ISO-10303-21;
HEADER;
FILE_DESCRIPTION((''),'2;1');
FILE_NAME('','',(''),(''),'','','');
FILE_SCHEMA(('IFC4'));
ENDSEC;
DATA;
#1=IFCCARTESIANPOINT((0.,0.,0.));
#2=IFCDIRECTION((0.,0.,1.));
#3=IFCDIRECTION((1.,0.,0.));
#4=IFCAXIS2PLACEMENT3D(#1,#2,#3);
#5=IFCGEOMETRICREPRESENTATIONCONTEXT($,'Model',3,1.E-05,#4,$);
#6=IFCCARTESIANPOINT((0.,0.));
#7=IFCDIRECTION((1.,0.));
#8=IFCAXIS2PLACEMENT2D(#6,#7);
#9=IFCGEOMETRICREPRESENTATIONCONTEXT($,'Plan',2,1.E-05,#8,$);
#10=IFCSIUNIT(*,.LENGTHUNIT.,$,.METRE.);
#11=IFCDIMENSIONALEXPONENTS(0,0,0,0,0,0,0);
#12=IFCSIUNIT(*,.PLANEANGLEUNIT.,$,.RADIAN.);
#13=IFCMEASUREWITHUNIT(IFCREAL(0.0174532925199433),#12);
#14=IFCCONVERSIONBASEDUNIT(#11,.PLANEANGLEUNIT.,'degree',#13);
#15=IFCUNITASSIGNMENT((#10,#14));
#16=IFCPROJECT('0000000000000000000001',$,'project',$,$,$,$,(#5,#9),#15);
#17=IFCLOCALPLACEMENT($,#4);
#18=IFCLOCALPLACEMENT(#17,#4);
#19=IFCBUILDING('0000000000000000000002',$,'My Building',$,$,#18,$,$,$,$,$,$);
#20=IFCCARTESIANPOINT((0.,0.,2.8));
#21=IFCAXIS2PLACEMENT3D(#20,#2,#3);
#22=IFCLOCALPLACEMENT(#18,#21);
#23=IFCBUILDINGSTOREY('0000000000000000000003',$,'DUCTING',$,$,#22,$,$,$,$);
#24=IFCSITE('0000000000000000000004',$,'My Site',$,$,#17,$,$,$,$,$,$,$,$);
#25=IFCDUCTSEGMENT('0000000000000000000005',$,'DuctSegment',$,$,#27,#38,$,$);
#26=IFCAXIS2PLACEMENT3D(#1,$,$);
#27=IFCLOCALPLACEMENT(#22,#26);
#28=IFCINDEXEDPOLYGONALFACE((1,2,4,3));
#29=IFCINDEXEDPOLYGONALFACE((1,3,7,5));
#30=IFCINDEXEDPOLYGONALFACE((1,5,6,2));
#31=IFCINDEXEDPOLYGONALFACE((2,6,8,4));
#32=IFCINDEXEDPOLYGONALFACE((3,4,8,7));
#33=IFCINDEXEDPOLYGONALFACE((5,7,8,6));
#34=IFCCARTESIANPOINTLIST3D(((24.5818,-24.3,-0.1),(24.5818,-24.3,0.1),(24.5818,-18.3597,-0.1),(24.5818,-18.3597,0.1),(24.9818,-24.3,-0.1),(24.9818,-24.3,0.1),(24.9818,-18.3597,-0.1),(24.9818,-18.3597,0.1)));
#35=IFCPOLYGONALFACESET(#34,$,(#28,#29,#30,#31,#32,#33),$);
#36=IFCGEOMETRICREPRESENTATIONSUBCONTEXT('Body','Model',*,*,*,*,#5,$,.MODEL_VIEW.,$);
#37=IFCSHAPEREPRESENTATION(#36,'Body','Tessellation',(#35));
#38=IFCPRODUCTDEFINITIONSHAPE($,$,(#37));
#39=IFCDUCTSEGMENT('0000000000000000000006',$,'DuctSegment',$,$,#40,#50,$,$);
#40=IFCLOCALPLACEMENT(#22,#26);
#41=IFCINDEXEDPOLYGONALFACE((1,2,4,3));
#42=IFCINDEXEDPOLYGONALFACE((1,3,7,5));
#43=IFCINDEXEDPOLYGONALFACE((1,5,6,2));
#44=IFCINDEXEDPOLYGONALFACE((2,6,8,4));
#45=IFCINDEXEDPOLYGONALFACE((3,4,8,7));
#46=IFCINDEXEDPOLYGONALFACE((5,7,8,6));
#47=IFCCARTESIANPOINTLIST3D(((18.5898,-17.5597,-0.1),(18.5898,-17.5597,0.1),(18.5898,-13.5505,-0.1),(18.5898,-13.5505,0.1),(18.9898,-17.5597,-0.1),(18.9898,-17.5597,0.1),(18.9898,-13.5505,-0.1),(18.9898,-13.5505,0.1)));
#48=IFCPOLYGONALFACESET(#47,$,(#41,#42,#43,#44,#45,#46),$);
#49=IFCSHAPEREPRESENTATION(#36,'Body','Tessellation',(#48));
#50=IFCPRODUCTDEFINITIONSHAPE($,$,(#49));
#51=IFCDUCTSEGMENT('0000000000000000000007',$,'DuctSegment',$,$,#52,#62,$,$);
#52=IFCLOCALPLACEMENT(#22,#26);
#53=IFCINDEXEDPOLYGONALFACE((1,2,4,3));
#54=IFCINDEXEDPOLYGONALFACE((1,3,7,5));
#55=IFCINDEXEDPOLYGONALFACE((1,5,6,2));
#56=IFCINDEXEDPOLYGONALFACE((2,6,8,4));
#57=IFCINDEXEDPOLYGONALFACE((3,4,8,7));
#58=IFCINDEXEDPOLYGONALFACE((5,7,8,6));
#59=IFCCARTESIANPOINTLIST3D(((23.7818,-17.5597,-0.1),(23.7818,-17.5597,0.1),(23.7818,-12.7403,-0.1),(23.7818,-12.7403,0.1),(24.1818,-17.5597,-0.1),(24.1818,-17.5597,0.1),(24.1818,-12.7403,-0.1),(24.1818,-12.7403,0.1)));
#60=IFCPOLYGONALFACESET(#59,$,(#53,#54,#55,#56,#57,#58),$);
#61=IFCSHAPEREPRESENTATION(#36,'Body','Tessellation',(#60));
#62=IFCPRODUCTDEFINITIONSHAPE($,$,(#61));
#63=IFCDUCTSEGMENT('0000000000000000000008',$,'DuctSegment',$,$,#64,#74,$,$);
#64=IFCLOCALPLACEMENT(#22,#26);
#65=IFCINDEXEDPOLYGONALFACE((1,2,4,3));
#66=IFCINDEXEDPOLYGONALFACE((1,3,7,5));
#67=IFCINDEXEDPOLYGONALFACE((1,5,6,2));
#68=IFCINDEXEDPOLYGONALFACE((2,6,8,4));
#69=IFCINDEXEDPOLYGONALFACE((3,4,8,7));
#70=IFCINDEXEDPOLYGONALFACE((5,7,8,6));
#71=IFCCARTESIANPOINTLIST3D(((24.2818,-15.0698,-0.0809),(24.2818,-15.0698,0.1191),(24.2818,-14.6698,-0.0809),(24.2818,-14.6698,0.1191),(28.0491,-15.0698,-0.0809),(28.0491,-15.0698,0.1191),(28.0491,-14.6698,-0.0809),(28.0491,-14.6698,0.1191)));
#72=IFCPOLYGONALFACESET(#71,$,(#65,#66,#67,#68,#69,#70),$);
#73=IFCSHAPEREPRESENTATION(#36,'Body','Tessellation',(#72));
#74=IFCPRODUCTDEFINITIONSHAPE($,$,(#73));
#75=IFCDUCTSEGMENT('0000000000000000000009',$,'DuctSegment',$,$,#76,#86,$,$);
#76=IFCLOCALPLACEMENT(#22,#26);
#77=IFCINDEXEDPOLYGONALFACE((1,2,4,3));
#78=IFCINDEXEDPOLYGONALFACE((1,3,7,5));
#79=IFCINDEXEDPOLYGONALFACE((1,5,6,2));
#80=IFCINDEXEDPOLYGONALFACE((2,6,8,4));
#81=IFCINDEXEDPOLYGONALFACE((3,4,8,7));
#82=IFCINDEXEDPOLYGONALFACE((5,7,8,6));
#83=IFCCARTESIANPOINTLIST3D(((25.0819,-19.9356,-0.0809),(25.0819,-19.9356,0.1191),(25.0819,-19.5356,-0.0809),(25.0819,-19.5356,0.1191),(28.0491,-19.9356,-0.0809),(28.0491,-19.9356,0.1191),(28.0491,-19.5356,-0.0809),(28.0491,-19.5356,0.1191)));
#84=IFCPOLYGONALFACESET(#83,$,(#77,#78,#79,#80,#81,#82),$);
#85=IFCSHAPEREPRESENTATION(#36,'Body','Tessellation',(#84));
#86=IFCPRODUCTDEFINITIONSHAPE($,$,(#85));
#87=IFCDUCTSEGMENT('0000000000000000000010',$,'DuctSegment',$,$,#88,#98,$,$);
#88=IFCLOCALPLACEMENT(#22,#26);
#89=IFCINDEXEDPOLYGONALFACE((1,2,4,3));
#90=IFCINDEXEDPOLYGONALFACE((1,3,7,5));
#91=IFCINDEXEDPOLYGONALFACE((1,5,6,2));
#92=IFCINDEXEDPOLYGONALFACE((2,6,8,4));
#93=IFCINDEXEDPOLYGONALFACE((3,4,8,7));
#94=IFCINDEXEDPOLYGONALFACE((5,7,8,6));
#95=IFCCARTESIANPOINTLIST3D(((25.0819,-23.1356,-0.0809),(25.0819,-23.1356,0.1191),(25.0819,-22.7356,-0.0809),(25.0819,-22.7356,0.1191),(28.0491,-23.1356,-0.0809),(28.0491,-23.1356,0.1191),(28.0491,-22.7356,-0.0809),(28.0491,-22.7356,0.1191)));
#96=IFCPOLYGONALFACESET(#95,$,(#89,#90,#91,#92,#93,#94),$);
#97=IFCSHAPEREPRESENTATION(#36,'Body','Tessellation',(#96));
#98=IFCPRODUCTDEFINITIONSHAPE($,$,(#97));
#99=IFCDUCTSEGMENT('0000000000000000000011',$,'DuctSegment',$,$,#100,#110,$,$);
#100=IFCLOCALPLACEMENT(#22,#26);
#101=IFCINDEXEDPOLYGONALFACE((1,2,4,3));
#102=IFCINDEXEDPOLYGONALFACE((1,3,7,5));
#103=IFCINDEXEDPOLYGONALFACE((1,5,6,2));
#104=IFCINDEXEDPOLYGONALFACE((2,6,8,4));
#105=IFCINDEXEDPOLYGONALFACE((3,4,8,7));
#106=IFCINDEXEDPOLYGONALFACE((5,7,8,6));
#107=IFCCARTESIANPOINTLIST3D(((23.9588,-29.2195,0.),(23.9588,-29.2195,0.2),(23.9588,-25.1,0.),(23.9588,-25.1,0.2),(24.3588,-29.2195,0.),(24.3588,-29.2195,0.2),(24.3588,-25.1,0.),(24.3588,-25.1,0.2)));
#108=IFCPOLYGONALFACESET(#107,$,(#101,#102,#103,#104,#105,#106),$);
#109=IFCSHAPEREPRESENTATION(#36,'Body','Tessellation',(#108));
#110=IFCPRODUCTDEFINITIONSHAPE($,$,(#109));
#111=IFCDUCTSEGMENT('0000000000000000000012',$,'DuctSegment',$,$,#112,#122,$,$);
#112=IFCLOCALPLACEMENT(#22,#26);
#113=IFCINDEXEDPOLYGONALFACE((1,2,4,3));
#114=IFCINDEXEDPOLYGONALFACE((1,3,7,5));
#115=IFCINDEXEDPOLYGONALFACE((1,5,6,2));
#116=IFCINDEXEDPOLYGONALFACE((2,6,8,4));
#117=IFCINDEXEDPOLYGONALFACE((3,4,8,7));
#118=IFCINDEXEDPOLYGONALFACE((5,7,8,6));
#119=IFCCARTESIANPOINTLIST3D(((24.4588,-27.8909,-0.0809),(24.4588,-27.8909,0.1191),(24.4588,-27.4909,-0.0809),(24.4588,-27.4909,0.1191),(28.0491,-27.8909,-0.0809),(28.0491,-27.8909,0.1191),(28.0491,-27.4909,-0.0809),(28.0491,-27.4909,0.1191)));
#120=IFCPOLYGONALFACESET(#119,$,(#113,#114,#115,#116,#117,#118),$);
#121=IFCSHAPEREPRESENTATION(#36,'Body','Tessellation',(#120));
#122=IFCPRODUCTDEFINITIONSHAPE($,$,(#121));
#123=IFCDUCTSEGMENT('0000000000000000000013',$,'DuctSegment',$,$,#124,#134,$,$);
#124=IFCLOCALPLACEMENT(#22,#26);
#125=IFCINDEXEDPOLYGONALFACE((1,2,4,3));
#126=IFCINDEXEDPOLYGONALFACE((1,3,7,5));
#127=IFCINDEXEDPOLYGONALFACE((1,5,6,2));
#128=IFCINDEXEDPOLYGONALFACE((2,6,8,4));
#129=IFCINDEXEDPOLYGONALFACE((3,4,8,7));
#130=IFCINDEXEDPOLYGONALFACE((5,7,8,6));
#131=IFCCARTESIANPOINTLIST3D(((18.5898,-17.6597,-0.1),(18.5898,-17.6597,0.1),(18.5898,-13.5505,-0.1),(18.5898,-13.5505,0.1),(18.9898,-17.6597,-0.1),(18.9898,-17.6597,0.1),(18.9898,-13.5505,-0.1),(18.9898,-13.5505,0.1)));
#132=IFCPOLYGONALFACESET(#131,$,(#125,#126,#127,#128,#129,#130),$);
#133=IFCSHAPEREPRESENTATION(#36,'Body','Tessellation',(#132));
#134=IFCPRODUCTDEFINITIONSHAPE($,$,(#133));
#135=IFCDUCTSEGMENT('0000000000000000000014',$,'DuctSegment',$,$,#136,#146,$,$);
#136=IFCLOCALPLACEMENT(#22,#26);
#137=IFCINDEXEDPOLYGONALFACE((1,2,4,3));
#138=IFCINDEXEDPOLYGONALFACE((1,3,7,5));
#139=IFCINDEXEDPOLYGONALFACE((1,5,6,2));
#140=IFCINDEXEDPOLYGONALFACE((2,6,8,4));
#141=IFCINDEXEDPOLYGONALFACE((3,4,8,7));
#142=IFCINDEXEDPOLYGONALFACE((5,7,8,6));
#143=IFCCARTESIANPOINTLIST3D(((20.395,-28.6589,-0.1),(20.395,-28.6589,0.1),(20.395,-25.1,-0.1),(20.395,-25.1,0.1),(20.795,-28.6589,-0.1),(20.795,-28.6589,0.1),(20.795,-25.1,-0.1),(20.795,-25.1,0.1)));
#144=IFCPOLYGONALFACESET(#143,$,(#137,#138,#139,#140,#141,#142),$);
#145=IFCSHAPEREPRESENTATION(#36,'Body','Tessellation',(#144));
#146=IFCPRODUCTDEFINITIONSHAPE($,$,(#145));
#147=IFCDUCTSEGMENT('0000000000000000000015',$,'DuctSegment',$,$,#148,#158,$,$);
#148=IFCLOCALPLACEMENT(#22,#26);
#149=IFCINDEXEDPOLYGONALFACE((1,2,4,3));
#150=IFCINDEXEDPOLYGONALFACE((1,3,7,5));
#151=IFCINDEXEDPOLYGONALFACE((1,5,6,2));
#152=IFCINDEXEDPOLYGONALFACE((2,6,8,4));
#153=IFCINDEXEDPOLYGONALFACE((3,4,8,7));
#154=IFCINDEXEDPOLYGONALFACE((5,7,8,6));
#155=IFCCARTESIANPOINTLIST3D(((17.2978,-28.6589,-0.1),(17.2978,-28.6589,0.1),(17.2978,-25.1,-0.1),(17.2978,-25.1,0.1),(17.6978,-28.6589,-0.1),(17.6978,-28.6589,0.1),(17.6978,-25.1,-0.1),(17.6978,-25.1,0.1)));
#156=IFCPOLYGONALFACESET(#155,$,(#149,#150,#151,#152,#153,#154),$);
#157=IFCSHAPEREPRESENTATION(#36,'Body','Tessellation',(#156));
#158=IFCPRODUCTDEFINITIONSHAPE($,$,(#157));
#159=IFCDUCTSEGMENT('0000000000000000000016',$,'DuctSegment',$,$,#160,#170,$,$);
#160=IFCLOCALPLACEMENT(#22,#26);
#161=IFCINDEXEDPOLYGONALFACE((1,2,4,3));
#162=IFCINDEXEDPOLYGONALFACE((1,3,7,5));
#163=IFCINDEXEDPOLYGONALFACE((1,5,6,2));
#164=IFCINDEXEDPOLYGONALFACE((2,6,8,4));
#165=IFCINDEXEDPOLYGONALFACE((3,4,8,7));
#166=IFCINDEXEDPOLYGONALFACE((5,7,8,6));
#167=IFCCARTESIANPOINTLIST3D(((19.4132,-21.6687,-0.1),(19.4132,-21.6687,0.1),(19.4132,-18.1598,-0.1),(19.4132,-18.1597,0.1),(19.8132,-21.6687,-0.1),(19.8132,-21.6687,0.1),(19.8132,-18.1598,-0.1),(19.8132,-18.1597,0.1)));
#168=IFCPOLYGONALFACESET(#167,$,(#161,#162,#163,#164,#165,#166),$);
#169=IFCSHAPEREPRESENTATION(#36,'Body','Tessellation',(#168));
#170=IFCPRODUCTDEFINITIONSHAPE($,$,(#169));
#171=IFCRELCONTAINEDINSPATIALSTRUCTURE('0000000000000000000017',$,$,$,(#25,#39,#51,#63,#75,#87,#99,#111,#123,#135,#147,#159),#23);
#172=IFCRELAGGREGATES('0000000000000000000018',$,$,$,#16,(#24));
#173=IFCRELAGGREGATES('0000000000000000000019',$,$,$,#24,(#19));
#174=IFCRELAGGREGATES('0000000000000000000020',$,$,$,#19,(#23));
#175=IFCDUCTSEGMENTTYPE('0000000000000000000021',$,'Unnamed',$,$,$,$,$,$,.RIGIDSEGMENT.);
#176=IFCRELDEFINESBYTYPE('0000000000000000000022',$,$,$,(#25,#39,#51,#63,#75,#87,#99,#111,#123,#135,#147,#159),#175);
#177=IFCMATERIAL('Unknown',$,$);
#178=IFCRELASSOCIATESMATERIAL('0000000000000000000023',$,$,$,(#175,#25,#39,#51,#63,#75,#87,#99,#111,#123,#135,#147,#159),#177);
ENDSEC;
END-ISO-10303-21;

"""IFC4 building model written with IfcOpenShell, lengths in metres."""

from ifc_helpers import new_model, entity, si_unit, converted_unit, frame, origin_with_axes, origin_2d_with_axis, place, context, subcontext, project, spatial, rectangle, extrude, material, material_profile, profile_set, profile_usage, type_object, element, save


model = new_model("IFC4")

# Units and contexts
model_context = context("Model", 3, precision=1e-05, world=origin_with_axes())
plan_context = context("Plan", 2, precision=1e-05, world=origin_2d_with_axis())
body_context = subcontext(model_context, "Body", "Model", "MODEL_VIEW")
ifc_project = project(units=[si_unit("LENGTHUNIT", "METRE"), converted_unit("PLANEANGLEUNIT", "degree", entity("IfcReal", 0.0174532925199433), si_unit("PLANEANGLEUNIT", "RADIAN"), dimensions=[0, 0, 0, 0, 0, 0, 0])], contexts=[model_context, plan_context])

# Site, building, storey
site_placement = place(None, origin_with_axes())
site = spatial("IfcSite", under=ifc_project, at=site_placement, Name="My Site")
building_placement = place(site_placement, origin_with_axes())
building = spatial("IfcBuilding", under=site, at=building_placement, Name="My Building")
storey_placement = place(building_placement, frame((0.0, 0.0, 2.8), z_axis=(0.0, 0.0, 1.0), x_axis=(1.0, 0.0, 0.0)))
storey = spatial("IfcBuildingStorey", under=building, at=storey_placement, Name="DUCTING")

# Duct segments
ifc_material = material(Name="Unknown")
ifc_material_profile_1 = material_profile(ifc_material, rectangle(XDim=0.4, YDim=0.2))
ifc_profile_set_1 = profile_set([ifc_material_profile_1])
ifc_profile_usage_1 = profile_usage(ifc_profile_set_1, cardinal=5)
duct_segment_type = type_object("IfcDuctSegmentType", Name="Unnamed", PredefinedType="RIGIDSEGMENT", material=ifc_profile_set_1)
duct_segment_1_placement = place(storey_placement, frame((24.7818, -18.3597, 0.0), z_axis=(0.0, -1.0, 0.0), x_axis=(1.0, 0.0, 0.0)))
element("IfcDuctSegment", 1, at=duct_segment_1_placement, inside=storey, type_object=duct_segment_type, material=ifc_profile_usage_1, Name="DuctSegment", context=body_context, shape_type="SweptSolid", body=[
    extrude(rectangle(XDim=0.4, YDim=0.2), origin_with_axes(), (0.0, 0.0, 1.0), 5.9403),
])
ifc_profile_usage_2 = profile_usage(ifc_profile_set_1, cardinal=5)
duct_segment_2_placement = place(storey_placement, frame((18.7898, -13.5505, 0.0), z_axis=(0.0, -1.0, 0.0), x_axis=(1.0, 0.0, 0.0)))
element("IfcDuctSegment", 2, at=duct_segment_2_placement, inside=storey, type_object=duct_segment_type, material=ifc_profile_usage_2, Name="DuctSegment", context=body_context, shape_type="SweptSolid", body=[
    extrude(rectangle(XDim=0.4, YDim=0.2), origin_with_axes(), (0.0, 0.0, 1.0), 4.0092),
])
ifc_profile_usage_3 = profile_usage(ifc_profile_set_1, cardinal=5)
duct_segment_3_placement = place(storey_placement, frame((23.9818, -12.7403, 0.0), z_axis=(0.0, -1.0, 0.0), x_axis=(1.0, 0.0, 0.0)))
element("IfcDuctSegment", 3, at=duct_segment_3_placement, inside=storey, type_object=duct_segment_type, material=ifc_profile_usage_3, Name="DuctSegment", context=body_context, shape_type="SweptSolid", body=[
    extrude(rectangle(XDim=0.4, YDim=0.2), origin_with_axes(), (0.0, 0.0, 1.0), 4.8195),
])
ifc_profile_usage_4 = profile_usage(ifc_profile_set_1, cardinal=5)
duct_segment_4_placement = place(storey_placement, frame((28.0491, -14.8698, 0.0191), z_axis=(-1.0, 0.0, 0.0), x_axis=(0.0, -1.0, 0.0)))
element("IfcDuctSegment", 4, at=duct_segment_4_placement, inside=storey, type_object=duct_segment_type, material=ifc_profile_usage_4, Name="DuctSegment", context=body_context, shape_type="SweptSolid", body=[
    extrude(rectangle(XDim=0.4, YDim=0.2), origin_with_axes(), (0.0, 0.0, 1.0), 3.7673),
])
ifc_profile_usage_5 = profile_usage(ifc_profile_set_1, cardinal=5)
duct_segment_5_placement = place(storey_placement, frame((28.0491, -19.7356, 0.0191), z_axis=(-1.0, 0.0, 0.0), x_axis=(0.0, -1.0, 0.0)))
element("IfcDuctSegment", 5, at=duct_segment_5_placement, inside=storey, type_object=duct_segment_type, material=ifc_profile_usage_5, Name="DuctSegment", context=body_context, shape_type="SweptSolid", body=[
    extrude(rectangle(XDim=0.4, YDim=0.2), origin_with_axes(), (0.0, 0.0, 1.0), 2.9672),
])
ifc_profile_usage_6 = profile_usage(ifc_profile_set_1, cardinal=5)
duct_segment_6_placement = place(storey_placement, frame((28.0491, -22.9356, 0.0191), z_axis=(-1.0, 0.0, 0.0), x_axis=(0.0, -1.0, 0.0)))
element("IfcDuctSegment", 6, at=duct_segment_6_placement, inside=storey, type_object=duct_segment_type, material=ifc_profile_usage_6, Name="DuctSegment", context=body_context, shape_type="SweptSolid", body=[
    extrude(rectangle(XDim=0.4, YDim=0.2), origin_with_axes(), (0.0, 0.0, 1.0), 2.9672),
])
ifc_profile_usage_7 = profile_usage(ifc_profile_set_1, cardinal=5)
duct_segment_7_placement = place(storey_placement, frame((24.1588, -25.1, 0.1), z_axis=(0.0, -1.0, 0.0), x_axis=(1.0, 0.0, 0.0)))
element("IfcDuctSegment", 7, at=duct_segment_7_placement, inside=storey, type_object=duct_segment_type, material=ifc_profile_usage_7, Name="DuctSegment", context=body_context, shape_type="SweptSolid", body=[
    extrude(rectangle(XDim=0.4, YDim=0.2), origin_with_axes(), (0.0, 0.0, 1.0), 4.1195),
])
ifc_profile_usage_8 = profile_usage(ifc_profile_set_1, cardinal=5)
duct_segment_8_placement = place(storey_placement, frame((28.0491, -27.6909, 0.0191), z_axis=(-1.0, 0.0, 0.0), x_axis=(0.0, -1.0, 0.0)))
element("IfcDuctSegment", 8, at=duct_segment_8_placement, inside=storey, type_object=duct_segment_type, material=ifc_profile_usage_8, Name="DuctSegment", context=body_context, shape_type="SweptSolid", body=[
    extrude(rectangle(XDim=0.4, YDim=0.2), origin_with_axes(), (0.0, 0.0, 1.0), 3.5903),
])
ifc_profile_usage_9 = profile_usage(ifc_profile_set_1, cardinal=5)
duct_segment_9_placement = place(storey_placement, frame((18.7898, -13.5505, 0.0), z_axis=(0.0, -1.0, 0.0), x_axis=(1.0, 0.0, 0.0)))
element("IfcDuctSegment", 9, at=duct_segment_9_placement, inside=storey, type_object=duct_segment_type, material=ifc_profile_usage_9, Name="DuctSegment", context=body_context, shape_type="SweptSolid", body=[
    extrude(rectangle(XDim=0.4, YDim=0.2), origin_with_axes(), (0.0, 0.0, 1.0), 4.1092),
])
ifc_profile_usage_10 = profile_usage(ifc_profile_set_1, cardinal=5)
duct_segment_10_placement = place(storey_placement, frame((20.595, -25.1, 0.0), z_axis=(0.0, -1.0, 0.0), x_axis=(1.0, 0.0, 0.0)))
element("IfcDuctSegment", 10, at=duct_segment_10_placement, inside=storey, type_object=duct_segment_type, material=ifc_profile_usage_10, Name="DuctSegment", context=body_context, shape_type="SweptSolid", body=[
    extrude(rectangle(XDim=0.4, YDim=0.2), origin_with_axes(), (0.0, 0.0, 1.0), 3.5589),
])
ifc_profile_usage_11 = profile_usage(ifc_profile_set_1, cardinal=5)
duct_segment_11_placement = place(storey_placement, frame((17.4978, -25.1, 0.0), z_axis=(0.0, -1.0, 0.0), x_axis=(1.0, 0.0, 0.0)))
element("IfcDuctSegment", 11, at=duct_segment_11_placement, inside=storey, type_object=duct_segment_type, material=ifc_profile_usage_11, Name="DuctSegment", context=body_context, shape_type="SweptSolid", body=[
    extrude(rectangle(XDim=0.4, YDim=0.2), origin_with_axes(), (0.0, 0.0, 1.0), 3.5589),
])
ifc_profile_usage_12 = profile_usage(ifc_profile_set_1, cardinal=5)
duct_segment_12_placement = place(storey_placement, frame((19.6132, -18.1597, 0.0), z_axis=(0.0, -1.0, 0.0), x_axis=(1.0, 0.0, 0.0)))
element("IfcDuctSegment", 12, at=duct_segment_12_placement, inside=storey, type_object=duct_segment_type, material=ifc_profile_usage_12, Name="DuctSegment", context=body_context, shape_type="SweptSolid", body=[
    extrude(rectangle(XDim=0.4, YDim=0.2), origin_with_axes(), (0.0, 0.0, 1.0), 3.5089),
])

save(model, "model.ifc")
